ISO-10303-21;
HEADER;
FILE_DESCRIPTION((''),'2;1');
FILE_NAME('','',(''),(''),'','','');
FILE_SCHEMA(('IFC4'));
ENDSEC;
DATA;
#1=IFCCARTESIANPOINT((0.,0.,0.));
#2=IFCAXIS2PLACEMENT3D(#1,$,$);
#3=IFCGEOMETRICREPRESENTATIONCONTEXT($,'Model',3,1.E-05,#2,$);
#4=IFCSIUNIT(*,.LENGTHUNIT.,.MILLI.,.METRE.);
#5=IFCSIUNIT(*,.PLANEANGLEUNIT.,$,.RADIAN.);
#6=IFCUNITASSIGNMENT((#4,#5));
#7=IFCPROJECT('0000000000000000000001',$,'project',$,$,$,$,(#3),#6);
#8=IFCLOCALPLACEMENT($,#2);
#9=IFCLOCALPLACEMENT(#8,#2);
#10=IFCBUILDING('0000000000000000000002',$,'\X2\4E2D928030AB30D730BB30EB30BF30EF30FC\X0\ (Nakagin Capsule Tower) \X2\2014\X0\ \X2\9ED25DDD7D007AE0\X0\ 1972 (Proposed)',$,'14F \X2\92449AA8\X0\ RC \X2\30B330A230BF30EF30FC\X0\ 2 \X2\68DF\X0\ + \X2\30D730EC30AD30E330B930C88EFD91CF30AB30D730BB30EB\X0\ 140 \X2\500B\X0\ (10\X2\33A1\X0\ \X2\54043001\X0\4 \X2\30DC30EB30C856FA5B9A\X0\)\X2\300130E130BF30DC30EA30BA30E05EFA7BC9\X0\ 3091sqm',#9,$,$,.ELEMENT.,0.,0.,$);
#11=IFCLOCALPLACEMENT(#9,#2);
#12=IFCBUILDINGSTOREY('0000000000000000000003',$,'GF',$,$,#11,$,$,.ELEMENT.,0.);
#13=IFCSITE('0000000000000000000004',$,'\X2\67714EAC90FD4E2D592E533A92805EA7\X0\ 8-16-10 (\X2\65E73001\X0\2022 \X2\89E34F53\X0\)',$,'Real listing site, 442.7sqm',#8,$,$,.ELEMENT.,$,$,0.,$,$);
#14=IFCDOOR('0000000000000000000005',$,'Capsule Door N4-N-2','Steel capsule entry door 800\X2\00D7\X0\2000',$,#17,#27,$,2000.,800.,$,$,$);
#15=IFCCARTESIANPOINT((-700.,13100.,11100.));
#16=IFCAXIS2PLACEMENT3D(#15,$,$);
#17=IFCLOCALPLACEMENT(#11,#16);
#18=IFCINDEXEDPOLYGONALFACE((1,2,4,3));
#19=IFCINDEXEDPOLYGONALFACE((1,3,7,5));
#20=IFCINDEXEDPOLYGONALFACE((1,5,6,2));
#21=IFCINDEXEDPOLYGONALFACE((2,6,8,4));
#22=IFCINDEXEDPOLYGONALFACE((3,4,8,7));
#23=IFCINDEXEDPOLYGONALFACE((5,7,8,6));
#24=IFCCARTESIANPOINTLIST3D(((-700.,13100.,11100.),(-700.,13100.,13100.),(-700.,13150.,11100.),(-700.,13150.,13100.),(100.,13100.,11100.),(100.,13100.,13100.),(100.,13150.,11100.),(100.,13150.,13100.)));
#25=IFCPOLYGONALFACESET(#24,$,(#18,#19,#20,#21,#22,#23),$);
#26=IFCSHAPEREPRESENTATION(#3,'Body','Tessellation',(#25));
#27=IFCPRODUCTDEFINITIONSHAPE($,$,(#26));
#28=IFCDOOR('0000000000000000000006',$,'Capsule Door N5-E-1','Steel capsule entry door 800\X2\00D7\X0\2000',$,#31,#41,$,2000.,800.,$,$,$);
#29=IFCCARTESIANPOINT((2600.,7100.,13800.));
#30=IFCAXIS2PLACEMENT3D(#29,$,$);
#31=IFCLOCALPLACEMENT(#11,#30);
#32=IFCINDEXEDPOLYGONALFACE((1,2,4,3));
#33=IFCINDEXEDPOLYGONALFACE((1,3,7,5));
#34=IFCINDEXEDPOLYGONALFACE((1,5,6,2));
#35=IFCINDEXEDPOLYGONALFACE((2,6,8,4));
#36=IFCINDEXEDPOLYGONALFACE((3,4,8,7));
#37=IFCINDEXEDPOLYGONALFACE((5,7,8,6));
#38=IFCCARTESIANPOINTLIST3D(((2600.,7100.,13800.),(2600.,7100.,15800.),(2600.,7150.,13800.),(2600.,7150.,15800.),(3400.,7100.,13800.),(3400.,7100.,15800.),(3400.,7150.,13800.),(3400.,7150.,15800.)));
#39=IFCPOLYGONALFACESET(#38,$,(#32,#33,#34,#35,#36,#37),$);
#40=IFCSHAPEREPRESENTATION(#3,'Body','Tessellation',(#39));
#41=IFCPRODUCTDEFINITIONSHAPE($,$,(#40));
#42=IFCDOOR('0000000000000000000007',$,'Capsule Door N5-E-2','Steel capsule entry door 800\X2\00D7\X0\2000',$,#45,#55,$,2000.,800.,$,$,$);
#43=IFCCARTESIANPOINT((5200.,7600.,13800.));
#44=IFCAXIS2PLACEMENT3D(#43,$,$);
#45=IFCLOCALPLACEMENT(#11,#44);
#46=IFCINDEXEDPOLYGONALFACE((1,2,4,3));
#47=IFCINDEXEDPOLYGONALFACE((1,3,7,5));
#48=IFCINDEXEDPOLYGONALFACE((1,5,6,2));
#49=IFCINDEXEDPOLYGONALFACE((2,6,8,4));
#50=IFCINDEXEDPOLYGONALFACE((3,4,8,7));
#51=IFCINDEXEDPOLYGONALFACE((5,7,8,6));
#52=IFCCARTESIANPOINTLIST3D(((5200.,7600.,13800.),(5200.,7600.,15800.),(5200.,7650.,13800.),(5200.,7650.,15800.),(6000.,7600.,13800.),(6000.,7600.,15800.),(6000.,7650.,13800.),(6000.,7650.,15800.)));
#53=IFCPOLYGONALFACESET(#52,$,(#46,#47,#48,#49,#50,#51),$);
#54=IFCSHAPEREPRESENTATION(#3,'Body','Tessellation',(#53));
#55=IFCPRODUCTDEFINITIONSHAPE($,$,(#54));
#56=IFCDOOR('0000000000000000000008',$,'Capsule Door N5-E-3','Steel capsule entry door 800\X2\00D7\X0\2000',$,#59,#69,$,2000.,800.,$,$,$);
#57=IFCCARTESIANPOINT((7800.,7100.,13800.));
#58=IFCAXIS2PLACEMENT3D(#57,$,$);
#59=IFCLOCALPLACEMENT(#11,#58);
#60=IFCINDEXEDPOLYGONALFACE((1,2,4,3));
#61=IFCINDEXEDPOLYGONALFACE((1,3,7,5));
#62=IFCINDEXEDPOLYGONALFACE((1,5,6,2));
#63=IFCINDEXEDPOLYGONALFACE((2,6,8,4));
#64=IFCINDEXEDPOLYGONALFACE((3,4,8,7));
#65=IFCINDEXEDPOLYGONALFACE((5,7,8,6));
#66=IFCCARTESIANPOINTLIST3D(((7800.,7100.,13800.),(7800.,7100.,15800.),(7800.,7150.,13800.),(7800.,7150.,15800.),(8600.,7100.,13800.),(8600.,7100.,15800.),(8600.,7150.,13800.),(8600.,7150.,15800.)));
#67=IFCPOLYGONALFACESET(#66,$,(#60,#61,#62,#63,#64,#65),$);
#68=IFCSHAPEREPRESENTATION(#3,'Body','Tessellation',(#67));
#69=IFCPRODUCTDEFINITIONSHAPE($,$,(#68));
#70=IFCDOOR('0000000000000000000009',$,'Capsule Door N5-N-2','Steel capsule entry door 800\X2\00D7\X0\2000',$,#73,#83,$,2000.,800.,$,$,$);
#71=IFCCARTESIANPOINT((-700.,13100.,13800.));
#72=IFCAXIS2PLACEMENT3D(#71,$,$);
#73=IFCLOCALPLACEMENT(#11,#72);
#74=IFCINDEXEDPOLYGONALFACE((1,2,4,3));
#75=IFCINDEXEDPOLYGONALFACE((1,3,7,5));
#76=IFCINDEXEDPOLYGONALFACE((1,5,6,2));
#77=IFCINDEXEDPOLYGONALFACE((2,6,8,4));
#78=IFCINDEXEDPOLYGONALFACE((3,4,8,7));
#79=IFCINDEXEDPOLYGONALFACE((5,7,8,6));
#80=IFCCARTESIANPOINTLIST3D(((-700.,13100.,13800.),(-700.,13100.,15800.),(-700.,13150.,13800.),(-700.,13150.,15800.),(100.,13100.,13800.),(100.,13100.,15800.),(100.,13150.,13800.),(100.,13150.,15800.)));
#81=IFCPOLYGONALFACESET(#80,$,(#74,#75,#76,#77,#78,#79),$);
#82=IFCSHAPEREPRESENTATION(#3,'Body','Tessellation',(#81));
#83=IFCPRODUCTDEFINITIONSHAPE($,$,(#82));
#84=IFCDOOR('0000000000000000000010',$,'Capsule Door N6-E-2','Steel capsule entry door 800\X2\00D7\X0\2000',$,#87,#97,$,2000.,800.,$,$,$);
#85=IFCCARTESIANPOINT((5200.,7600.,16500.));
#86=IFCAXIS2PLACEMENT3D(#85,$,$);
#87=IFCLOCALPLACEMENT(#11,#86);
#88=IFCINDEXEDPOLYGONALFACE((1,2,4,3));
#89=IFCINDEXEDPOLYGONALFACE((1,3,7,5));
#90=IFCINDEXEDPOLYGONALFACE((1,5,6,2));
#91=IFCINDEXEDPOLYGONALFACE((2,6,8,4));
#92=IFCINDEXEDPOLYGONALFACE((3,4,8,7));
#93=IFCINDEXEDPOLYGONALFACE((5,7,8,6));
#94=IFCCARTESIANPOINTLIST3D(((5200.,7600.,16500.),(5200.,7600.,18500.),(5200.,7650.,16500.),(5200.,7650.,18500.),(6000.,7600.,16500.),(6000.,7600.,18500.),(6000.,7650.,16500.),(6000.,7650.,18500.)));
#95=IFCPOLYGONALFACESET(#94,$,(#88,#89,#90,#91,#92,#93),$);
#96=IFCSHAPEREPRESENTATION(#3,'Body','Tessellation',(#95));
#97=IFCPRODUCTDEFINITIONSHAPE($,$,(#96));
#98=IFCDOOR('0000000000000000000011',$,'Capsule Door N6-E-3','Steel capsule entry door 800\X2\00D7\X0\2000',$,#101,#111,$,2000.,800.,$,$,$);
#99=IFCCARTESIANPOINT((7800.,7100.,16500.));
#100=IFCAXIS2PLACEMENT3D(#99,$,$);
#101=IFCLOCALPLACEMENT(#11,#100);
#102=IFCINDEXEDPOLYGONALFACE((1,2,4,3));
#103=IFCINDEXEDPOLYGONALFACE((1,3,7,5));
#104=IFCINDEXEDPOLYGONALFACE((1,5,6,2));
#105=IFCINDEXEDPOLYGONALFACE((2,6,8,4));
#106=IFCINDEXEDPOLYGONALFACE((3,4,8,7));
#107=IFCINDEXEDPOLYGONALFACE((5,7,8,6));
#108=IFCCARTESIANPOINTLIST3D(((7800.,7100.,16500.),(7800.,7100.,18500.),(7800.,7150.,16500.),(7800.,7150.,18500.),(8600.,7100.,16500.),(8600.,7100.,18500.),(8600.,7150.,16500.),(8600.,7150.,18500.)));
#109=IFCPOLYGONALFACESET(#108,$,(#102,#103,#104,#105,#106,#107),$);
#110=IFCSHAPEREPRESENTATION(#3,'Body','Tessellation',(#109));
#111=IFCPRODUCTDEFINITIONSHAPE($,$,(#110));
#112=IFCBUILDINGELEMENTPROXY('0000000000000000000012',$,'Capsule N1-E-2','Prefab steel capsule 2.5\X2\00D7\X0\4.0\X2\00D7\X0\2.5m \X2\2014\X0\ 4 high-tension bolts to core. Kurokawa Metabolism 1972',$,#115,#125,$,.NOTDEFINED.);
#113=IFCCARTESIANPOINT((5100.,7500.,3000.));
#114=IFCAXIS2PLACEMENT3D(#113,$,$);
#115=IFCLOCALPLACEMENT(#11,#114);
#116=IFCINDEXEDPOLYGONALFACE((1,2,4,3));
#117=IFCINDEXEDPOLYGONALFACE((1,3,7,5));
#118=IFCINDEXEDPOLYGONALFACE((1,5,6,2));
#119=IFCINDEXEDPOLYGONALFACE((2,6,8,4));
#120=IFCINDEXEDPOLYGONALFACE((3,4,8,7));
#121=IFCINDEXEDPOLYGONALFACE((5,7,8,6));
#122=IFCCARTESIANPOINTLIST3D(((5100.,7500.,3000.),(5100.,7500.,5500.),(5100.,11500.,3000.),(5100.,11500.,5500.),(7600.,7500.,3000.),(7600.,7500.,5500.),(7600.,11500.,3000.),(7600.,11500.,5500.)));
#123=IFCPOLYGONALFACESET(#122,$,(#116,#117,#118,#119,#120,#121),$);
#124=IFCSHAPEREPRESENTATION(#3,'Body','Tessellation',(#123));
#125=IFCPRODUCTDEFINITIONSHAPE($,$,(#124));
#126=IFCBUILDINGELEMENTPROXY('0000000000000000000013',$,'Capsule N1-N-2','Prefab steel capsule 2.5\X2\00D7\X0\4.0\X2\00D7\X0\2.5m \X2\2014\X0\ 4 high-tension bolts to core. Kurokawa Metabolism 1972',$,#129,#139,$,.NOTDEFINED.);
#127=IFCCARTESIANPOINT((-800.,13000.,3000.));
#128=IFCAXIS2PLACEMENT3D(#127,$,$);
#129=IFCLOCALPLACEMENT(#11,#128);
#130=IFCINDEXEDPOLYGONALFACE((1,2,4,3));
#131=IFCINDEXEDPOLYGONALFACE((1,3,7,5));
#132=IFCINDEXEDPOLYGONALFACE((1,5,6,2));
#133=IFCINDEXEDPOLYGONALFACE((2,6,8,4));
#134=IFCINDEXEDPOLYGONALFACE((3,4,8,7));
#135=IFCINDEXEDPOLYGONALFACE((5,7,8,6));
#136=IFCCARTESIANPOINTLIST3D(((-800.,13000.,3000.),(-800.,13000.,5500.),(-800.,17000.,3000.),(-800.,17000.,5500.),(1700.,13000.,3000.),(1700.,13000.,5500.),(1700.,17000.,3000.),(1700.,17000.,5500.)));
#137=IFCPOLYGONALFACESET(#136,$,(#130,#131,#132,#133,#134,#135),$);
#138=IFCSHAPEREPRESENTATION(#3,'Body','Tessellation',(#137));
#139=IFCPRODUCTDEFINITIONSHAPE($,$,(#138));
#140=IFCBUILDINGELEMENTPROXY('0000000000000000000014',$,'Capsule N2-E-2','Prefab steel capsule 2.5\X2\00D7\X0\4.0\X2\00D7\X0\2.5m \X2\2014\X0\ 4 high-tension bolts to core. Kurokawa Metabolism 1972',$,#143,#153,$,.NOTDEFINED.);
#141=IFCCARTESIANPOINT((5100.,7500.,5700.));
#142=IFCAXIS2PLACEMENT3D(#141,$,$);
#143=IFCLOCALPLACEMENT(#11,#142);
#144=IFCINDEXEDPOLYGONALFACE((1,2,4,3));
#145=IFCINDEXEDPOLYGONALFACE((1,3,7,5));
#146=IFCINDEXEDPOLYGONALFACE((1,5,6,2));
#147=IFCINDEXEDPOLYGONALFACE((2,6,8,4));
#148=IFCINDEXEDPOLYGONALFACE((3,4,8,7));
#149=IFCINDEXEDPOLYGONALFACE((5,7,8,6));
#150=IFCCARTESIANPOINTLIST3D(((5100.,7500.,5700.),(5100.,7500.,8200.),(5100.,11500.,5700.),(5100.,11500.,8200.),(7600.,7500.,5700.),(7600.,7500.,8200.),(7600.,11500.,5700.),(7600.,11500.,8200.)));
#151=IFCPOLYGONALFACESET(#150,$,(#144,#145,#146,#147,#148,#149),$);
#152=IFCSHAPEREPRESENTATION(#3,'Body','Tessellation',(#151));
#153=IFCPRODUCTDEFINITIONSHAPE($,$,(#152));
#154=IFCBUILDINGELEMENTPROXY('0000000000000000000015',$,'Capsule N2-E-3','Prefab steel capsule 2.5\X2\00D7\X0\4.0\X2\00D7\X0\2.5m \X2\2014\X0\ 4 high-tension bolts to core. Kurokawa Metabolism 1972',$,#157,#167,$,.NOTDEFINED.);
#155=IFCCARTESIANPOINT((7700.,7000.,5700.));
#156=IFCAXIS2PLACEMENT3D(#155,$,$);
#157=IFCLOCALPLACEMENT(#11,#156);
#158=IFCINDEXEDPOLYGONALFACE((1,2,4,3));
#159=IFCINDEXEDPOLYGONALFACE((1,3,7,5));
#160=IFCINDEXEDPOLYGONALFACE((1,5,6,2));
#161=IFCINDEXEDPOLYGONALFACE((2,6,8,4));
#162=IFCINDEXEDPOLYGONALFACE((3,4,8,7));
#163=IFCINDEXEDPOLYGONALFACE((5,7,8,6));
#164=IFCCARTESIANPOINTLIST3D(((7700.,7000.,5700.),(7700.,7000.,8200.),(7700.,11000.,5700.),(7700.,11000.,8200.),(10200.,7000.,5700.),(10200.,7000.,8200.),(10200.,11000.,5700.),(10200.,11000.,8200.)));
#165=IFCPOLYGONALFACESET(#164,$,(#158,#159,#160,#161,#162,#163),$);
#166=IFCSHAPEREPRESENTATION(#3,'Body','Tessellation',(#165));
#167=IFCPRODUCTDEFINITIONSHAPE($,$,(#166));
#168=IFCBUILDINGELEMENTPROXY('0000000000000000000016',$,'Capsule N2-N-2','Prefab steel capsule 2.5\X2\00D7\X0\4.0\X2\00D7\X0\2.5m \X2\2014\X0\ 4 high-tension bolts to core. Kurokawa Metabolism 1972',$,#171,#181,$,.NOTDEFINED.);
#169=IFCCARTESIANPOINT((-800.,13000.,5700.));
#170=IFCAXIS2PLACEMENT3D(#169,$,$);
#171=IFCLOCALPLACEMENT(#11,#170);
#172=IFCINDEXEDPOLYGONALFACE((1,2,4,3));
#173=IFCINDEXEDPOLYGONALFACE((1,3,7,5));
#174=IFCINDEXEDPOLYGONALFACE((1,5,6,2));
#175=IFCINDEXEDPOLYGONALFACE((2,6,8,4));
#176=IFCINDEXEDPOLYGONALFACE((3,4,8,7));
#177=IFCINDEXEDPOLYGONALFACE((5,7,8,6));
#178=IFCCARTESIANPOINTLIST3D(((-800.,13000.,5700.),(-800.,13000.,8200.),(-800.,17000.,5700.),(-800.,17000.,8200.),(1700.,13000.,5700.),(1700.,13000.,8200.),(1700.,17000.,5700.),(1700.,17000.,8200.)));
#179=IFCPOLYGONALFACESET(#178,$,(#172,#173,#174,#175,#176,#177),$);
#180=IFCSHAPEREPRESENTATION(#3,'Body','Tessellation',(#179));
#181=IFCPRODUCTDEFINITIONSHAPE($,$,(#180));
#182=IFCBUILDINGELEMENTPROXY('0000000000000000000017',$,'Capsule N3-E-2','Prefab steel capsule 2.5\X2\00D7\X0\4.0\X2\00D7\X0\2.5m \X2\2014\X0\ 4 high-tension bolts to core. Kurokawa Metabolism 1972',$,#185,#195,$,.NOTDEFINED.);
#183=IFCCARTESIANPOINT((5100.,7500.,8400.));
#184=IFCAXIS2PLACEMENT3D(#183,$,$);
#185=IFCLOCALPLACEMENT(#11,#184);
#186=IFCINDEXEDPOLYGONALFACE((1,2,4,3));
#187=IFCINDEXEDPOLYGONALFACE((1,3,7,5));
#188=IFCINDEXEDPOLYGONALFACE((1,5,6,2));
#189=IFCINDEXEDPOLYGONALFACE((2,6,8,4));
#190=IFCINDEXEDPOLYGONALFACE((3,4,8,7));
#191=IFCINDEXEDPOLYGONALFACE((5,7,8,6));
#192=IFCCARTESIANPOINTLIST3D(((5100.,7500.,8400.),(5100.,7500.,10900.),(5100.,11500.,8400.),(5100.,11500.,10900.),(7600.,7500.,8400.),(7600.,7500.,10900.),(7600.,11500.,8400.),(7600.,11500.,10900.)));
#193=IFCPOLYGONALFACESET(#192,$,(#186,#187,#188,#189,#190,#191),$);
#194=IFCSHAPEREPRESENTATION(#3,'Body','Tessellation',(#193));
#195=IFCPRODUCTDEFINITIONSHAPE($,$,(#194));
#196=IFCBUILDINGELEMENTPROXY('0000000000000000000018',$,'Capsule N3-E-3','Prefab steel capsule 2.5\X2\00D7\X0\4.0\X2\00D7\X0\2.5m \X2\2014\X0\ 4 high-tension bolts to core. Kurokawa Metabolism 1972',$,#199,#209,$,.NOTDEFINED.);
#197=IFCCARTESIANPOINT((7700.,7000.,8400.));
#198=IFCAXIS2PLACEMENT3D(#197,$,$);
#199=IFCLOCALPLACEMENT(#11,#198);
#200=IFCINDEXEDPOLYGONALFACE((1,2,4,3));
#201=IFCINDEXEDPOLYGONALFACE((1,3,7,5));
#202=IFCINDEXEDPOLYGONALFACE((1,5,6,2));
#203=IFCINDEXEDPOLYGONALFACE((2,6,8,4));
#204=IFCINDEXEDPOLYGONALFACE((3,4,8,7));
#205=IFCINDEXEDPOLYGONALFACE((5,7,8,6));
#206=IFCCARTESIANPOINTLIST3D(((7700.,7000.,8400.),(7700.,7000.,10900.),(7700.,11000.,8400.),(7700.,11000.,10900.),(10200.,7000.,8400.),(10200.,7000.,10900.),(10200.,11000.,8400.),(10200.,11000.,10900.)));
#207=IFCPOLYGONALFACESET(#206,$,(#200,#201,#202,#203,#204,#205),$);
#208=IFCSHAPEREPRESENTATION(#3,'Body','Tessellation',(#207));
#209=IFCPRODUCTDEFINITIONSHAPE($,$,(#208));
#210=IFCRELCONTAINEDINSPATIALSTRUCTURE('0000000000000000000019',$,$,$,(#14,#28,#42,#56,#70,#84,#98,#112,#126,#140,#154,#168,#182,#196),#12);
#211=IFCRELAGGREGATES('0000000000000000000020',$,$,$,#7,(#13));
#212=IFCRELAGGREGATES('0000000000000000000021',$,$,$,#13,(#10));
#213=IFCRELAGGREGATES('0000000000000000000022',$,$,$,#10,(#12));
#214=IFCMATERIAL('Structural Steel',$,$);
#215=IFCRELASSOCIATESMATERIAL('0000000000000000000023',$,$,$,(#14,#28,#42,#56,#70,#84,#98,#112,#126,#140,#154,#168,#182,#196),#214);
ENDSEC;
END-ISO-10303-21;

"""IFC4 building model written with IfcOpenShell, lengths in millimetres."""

from ifc_helpers import new_model, si_unit, frame, frame_2d, origin, place, context, project, spatial, rectangle, extrude, material, element, save


model = new_model("IFC4")

# Units and contexts
model_context = context("Model", 3, precision=1e-05, world=origin())
ifc_project = project(units=[si_unit("LENGTHUNIT", "METRE", prefix="MILLI"), si_unit("PLANEANGLEUNIT", "RADIAN")], contexts=[model_context])

# Site, building, storey
site_placement = place(None, origin())
site = spatial("IfcSite", under=ifc_project, at=site_placement, Name="東京都中央区銀座 8-16-10 (旧、2022 解体)", ObjectType="Real listing site, 442.7sqm", CompositionType="ELEMENT", RefElevation=0.0)
building_placement = place(site_placement, origin())
building = spatial("IfcBuilding", under=site, at=building_placement, Name="中銀カプセルタワー (Nakagin Capsule Tower) — 黒川紀章 1972 (Proposed)", ObjectType="14F 鉄骨 RC コアタワー 2 棟 + プレキャスト軽量カプセル 140 個 (10㎡ 各、4 ボルト固定)、メタボリズム建築 3091sqm", CompositionType="ELEMENT", ElevationOfRefHeight=0.0, ElevationOfTerrain=0.0)
storey_placement = place(building_placement, origin())
storey = spatial("IfcBuildingStorey", under=building, at=storey_placement, Name="GF", CompositionType="ELEMENT", Elevation=0.0)

# Doors
ifc_material_1 = material(Name="Structural Steel")
door_1_placement = place(storey_placement, frame((-700.0, 13100.0, 11100.0)))
element("IfcDoor", 1, at=door_1_placement, inside=storey, material=ifc_material_1, Name="Capsule Door N4-N-2", Description="Steel capsule entry door 800×2000", OverallHeight=2000.0, OverallWidth=800.0, context=model_context, shape_type="SweptSolid", body=[
    extrude(rectangle(XDim=800.0, YDim=50.0, at=frame_2d((400.0, 25.0))), frame((-700.0, 13100.0, 11100.0)), (0.0, 0.0, 1.0), 2000.0),
])
door_2_placement = place(storey_placement, frame((2600.0, 7100.0, 13800.0)))
element("IfcDoor", 2, at=door_2_placement, inside=storey, material=ifc_material_1, Name="Capsule Door N5-E-1", Description="Steel capsule entry door 800×2000", OverallHeight=2000.0, OverallWidth=800.0, context=model_context, shape_type="SweptSolid", body=[
    extrude(rectangle(XDim=800.0, YDim=50.0, at=frame_2d((400.0, 25.0))), frame((2600.0, 7100.0, 13800.0)), (0.0, 0.0, 1.0), 2000.0),
])
door_3_placement = place(storey_placement, frame((5200.0, 7600.0, 13800.0)))
element("IfcDoor", 3, at=door_3_placement, inside=storey, material=ifc_material_1, Name="Capsule Door N5-E-2", Description="Steel capsule entry door 800×2000", OverallHeight=2000.0, OverallWidth=800.0, context=model_context, shape_type="SweptSolid", body=[
    extrude(rectangle(XDim=800.0, YDim=50.0, at=frame_2d((400.0, 25.0))), frame((5200.0, 7600.0, 13800.0)), (0.0, 0.0, 1.0), 2000.0),
])
door_4_placement = place(storey_placement, frame((7800.0, 7100.0, 13800.0)))
element("IfcDoor", 4, at=door_4_placement, inside=storey, material=ifc_material_1, Name="Capsule Door N5-E-3", Description="Steel capsule entry door 800×2000", OverallHeight=2000.0, OverallWidth=800.0, context=model_context, shape_type="SweptSolid", body=[
    extrude(rectangle(XDim=800.0, YDim=50.0, at=frame_2d((400.0, 25.0))), frame((7800.0, 7100.0, 13800.0)), (0.0, 0.0, 1.0), 2000.0),
])
door_5_placement = place(storey_placement, frame((-700.0, 13100.0, 13800.0)))
element("IfcDoor", 5, at=door_5_placement, inside=storey, material=ifc_material_1, Name="Capsule Door N5-N-2", Description="Steel capsule entry door 800×2000", OverallHeight=2000.0, OverallWidth=800.0, context=model_context, shape_type="SweptSolid", body=[
    extrude(rectangle(XDim=800.0, YDim=50.0, at=frame_2d((400.0, 25.0))), frame((-700.0, 13100.0, 13800.0)), (0.0, 0.0, 1.0), 2000.0),
])
door_6_placement = place(storey_placement, frame((5200.0, 7600.0, 16500.0)))
element("IfcDoor", 6, at=door_6_placement, inside=storey, material=ifc_material_1, Name="Capsule Door N6-E-2", Description="Steel capsule entry door 800×2000", OverallHeight=2000.0, OverallWidth=800.0, context=model_context, shape_type="SweptSolid", body=[
    extrude(rectangle(XDim=800.0, YDim=50.0, at=frame_2d((400.0, 25.0))), frame((5200.0, 7600.0, 16500.0)), (0.0, 0.0, 1.0), 2000.0),
])
door_7_placement = place(storey_placement, frame((7800.0, 7100.0, 16500.0)))
element("IfcDoor", 7, at=door_7_placement, inside=storey, material=ifc_material_1, Name="Capsule Door N6-E-3", Description="Steel capsule entry door 800×2000", OverallHeight=2000.0, OverallWidth=800.0, context=model_context, shape_type="SweptSolid", body=[
    extrude(rectangle(XDim=800.0, YDim=50.0, at=frame_2d((400.0, 25.0))), frame((7800.0, 7100.0, 16500.0)), (0.0, 0.0, 1.0), 2000.0),
])

# Building element proxies
proxy_1_placement = place(storey_placement, frame((5100.0, 7500.0, 3000.0)))
element("IfcBuildingElementProxy", 8, at=proxy_1_placement, inside=storey, material=ifc_material_1, Name="Capsule N1-E-2", Description="Prefab steel capsule 2.5×4.0×2.5m — 4 high-tension bolts to core. Kurokawa Metabolism 1972", PredefinedType="NOTDEFINED", context=model_context, shape_type="SweptSolid", body=[
    extrude(rectangle(XDim=2500.0, YDim=4000.0, at=frame_2d((1250.0, 2000.0))), frame((5100.0, 7500.0, 3000.0)), (0.0, 0.0, 1.0), 2500.0),
])
proxy_2_placement = place(storey_placement, frame((-800.0, 13000.0, 3000.0)))
element("IfcBuildingElementProxy", 9, at=proxy_2_placement, inside=storey, material=ifc_material_1, Name="Capsule N1-N-2", Description="Prefab steel capsule 2.5×4.0×2.5m — 4 high-tension bolts to core. Kurokawa Metabolism 1972", PredefinedType="NOTDEFINED", context=model_context, shape_type="SweptSolid", body=[
    extrude(rectangle(XDim=2500.0, YDim=4000.0, at=frame_2d((1250.0, 2000.0))), frame((-800.0, 13000.0, 3000.0)), (0.0, 0.0, 1.0), 2500.0),
])
proxy_3_placement = place(storey_placement, frame((5100.0, 7500.0, 5700.0)))
element("IfcBuildingElementProxy", 10, at=proxy_3_placement, inside=storey, material=ifc_material_1, Name="Capsule N2-E-2", Description="Prefab steel capsule 2.5×4.0×2.5m — 4 high-tension bolts to core. Kurokawa Metabolism 1972", PredefinedType="NOTDEFINED", context=model_context, shape_type="SweptSolid", body=[
    extrude(rectangle(XDim=2500.0, YDim=4000.0, at=frame_2d((1250.0, 2000.0))), frame((5100.0, 7500.0, 5700.0)), (0.0, 0.0, 1.0), 2500.0),
])
proxy_4_placement = place(storey_placement, frame((7700.0, 7000.0, 5700.0)))
element("IfcBuildingElementProxy", 11, at=proxy_4_placement, inside=storey, material=ifc_material_1, Name="Capsule N2-E-3", Description="Prefab steel capsule 2.5×4.0×2.5m — 4 high-tension bolts to core. Kurokawa Metabolism 1972", PredefinedType="NOTDEFINED", context=model_context, shape_type="SweptSolid", body=[
    extrude(rectangle(XDim=2500.0, YDim=4000.0, at=frame_2d((1250.0, 2000.0))), frame((7700.0, 7000.0, 5700.0)), (0.0, 0.0, 1.0), 2500.0),
])
proxy_5_placement = place(storey_placement, frame((-800.0, 13000.0, 5700.0)))
element("IfcBuildingElementProxy", 12, at=proxy_5_placement, inside=storey, material=ifc_material_1, Name="Capsule N2-N-2", Description="Prefab steel capsule 2.5×4.0×2.5m — 4 high-tension bolts to core. Kurokawa Metabolism 1972", PredefinedType="NOTDEFINED", context=model_context, shape_type="SweptSolid", body=[
    extrude(rectangle(XDim=2500.0, YDim=4000.0, at=frame_2d((1250.0, 2000.0))), frame((-800.0, 13000.0, 5700.0)), (0.0, 0.0, 1.0), 2500.0),
])
proxy_6_placement = place(storey_placement, frame((5100.0, 7500.0, 8400.0)))
element("IfcBuildingElementProxy", 13, at=proxy_6_placement, inside=storey, material=ifc_material_1, Name="Capsule N3-E-2", Description="Prefab steel capsule 2.5×4.0×2.5m — 4 high-tension bolts to core. Kurokawa Metabolism 1972", PredefinedType="NOTDEFINED", context=model_context, shape_type="SweptSolid", body=[
    extrude(rectangle(XDim=2500.0, YDim=4000.0, at=frame_2d((1250.0, 2000.0))), frame((5100.0, 7500.0, 8400.0)), (0.0, 0.0, 1.0), 2500.0),
])
proxy_7_placement = place(storey_placement, frame((7700.0, 7000.0, 8400.0)))
element("IfcBuildingElementProxy", 14, at=proxy_7_placement, inside=storey, material=ifc_material_1, Name="Capsule N3-E-3", Description="Prefab steel capsule 2.5×4.0×2.5m — 4 high-tension bolts to core. Kurokawa Metabolism 1972", PredefinedType="NOTDEFINED", context=model_context, shape_type="SweptSolid", body=[
    extrude(rectangle(XDim=2500.0, YDim=4000.0, at=frame_2d((1250.0, 2000.0))), frame((7700.0, 7000.0, 8400.0)), (0.0, 0.0, 1.0), 2500.0),
])

save(model, "model.ifc")
